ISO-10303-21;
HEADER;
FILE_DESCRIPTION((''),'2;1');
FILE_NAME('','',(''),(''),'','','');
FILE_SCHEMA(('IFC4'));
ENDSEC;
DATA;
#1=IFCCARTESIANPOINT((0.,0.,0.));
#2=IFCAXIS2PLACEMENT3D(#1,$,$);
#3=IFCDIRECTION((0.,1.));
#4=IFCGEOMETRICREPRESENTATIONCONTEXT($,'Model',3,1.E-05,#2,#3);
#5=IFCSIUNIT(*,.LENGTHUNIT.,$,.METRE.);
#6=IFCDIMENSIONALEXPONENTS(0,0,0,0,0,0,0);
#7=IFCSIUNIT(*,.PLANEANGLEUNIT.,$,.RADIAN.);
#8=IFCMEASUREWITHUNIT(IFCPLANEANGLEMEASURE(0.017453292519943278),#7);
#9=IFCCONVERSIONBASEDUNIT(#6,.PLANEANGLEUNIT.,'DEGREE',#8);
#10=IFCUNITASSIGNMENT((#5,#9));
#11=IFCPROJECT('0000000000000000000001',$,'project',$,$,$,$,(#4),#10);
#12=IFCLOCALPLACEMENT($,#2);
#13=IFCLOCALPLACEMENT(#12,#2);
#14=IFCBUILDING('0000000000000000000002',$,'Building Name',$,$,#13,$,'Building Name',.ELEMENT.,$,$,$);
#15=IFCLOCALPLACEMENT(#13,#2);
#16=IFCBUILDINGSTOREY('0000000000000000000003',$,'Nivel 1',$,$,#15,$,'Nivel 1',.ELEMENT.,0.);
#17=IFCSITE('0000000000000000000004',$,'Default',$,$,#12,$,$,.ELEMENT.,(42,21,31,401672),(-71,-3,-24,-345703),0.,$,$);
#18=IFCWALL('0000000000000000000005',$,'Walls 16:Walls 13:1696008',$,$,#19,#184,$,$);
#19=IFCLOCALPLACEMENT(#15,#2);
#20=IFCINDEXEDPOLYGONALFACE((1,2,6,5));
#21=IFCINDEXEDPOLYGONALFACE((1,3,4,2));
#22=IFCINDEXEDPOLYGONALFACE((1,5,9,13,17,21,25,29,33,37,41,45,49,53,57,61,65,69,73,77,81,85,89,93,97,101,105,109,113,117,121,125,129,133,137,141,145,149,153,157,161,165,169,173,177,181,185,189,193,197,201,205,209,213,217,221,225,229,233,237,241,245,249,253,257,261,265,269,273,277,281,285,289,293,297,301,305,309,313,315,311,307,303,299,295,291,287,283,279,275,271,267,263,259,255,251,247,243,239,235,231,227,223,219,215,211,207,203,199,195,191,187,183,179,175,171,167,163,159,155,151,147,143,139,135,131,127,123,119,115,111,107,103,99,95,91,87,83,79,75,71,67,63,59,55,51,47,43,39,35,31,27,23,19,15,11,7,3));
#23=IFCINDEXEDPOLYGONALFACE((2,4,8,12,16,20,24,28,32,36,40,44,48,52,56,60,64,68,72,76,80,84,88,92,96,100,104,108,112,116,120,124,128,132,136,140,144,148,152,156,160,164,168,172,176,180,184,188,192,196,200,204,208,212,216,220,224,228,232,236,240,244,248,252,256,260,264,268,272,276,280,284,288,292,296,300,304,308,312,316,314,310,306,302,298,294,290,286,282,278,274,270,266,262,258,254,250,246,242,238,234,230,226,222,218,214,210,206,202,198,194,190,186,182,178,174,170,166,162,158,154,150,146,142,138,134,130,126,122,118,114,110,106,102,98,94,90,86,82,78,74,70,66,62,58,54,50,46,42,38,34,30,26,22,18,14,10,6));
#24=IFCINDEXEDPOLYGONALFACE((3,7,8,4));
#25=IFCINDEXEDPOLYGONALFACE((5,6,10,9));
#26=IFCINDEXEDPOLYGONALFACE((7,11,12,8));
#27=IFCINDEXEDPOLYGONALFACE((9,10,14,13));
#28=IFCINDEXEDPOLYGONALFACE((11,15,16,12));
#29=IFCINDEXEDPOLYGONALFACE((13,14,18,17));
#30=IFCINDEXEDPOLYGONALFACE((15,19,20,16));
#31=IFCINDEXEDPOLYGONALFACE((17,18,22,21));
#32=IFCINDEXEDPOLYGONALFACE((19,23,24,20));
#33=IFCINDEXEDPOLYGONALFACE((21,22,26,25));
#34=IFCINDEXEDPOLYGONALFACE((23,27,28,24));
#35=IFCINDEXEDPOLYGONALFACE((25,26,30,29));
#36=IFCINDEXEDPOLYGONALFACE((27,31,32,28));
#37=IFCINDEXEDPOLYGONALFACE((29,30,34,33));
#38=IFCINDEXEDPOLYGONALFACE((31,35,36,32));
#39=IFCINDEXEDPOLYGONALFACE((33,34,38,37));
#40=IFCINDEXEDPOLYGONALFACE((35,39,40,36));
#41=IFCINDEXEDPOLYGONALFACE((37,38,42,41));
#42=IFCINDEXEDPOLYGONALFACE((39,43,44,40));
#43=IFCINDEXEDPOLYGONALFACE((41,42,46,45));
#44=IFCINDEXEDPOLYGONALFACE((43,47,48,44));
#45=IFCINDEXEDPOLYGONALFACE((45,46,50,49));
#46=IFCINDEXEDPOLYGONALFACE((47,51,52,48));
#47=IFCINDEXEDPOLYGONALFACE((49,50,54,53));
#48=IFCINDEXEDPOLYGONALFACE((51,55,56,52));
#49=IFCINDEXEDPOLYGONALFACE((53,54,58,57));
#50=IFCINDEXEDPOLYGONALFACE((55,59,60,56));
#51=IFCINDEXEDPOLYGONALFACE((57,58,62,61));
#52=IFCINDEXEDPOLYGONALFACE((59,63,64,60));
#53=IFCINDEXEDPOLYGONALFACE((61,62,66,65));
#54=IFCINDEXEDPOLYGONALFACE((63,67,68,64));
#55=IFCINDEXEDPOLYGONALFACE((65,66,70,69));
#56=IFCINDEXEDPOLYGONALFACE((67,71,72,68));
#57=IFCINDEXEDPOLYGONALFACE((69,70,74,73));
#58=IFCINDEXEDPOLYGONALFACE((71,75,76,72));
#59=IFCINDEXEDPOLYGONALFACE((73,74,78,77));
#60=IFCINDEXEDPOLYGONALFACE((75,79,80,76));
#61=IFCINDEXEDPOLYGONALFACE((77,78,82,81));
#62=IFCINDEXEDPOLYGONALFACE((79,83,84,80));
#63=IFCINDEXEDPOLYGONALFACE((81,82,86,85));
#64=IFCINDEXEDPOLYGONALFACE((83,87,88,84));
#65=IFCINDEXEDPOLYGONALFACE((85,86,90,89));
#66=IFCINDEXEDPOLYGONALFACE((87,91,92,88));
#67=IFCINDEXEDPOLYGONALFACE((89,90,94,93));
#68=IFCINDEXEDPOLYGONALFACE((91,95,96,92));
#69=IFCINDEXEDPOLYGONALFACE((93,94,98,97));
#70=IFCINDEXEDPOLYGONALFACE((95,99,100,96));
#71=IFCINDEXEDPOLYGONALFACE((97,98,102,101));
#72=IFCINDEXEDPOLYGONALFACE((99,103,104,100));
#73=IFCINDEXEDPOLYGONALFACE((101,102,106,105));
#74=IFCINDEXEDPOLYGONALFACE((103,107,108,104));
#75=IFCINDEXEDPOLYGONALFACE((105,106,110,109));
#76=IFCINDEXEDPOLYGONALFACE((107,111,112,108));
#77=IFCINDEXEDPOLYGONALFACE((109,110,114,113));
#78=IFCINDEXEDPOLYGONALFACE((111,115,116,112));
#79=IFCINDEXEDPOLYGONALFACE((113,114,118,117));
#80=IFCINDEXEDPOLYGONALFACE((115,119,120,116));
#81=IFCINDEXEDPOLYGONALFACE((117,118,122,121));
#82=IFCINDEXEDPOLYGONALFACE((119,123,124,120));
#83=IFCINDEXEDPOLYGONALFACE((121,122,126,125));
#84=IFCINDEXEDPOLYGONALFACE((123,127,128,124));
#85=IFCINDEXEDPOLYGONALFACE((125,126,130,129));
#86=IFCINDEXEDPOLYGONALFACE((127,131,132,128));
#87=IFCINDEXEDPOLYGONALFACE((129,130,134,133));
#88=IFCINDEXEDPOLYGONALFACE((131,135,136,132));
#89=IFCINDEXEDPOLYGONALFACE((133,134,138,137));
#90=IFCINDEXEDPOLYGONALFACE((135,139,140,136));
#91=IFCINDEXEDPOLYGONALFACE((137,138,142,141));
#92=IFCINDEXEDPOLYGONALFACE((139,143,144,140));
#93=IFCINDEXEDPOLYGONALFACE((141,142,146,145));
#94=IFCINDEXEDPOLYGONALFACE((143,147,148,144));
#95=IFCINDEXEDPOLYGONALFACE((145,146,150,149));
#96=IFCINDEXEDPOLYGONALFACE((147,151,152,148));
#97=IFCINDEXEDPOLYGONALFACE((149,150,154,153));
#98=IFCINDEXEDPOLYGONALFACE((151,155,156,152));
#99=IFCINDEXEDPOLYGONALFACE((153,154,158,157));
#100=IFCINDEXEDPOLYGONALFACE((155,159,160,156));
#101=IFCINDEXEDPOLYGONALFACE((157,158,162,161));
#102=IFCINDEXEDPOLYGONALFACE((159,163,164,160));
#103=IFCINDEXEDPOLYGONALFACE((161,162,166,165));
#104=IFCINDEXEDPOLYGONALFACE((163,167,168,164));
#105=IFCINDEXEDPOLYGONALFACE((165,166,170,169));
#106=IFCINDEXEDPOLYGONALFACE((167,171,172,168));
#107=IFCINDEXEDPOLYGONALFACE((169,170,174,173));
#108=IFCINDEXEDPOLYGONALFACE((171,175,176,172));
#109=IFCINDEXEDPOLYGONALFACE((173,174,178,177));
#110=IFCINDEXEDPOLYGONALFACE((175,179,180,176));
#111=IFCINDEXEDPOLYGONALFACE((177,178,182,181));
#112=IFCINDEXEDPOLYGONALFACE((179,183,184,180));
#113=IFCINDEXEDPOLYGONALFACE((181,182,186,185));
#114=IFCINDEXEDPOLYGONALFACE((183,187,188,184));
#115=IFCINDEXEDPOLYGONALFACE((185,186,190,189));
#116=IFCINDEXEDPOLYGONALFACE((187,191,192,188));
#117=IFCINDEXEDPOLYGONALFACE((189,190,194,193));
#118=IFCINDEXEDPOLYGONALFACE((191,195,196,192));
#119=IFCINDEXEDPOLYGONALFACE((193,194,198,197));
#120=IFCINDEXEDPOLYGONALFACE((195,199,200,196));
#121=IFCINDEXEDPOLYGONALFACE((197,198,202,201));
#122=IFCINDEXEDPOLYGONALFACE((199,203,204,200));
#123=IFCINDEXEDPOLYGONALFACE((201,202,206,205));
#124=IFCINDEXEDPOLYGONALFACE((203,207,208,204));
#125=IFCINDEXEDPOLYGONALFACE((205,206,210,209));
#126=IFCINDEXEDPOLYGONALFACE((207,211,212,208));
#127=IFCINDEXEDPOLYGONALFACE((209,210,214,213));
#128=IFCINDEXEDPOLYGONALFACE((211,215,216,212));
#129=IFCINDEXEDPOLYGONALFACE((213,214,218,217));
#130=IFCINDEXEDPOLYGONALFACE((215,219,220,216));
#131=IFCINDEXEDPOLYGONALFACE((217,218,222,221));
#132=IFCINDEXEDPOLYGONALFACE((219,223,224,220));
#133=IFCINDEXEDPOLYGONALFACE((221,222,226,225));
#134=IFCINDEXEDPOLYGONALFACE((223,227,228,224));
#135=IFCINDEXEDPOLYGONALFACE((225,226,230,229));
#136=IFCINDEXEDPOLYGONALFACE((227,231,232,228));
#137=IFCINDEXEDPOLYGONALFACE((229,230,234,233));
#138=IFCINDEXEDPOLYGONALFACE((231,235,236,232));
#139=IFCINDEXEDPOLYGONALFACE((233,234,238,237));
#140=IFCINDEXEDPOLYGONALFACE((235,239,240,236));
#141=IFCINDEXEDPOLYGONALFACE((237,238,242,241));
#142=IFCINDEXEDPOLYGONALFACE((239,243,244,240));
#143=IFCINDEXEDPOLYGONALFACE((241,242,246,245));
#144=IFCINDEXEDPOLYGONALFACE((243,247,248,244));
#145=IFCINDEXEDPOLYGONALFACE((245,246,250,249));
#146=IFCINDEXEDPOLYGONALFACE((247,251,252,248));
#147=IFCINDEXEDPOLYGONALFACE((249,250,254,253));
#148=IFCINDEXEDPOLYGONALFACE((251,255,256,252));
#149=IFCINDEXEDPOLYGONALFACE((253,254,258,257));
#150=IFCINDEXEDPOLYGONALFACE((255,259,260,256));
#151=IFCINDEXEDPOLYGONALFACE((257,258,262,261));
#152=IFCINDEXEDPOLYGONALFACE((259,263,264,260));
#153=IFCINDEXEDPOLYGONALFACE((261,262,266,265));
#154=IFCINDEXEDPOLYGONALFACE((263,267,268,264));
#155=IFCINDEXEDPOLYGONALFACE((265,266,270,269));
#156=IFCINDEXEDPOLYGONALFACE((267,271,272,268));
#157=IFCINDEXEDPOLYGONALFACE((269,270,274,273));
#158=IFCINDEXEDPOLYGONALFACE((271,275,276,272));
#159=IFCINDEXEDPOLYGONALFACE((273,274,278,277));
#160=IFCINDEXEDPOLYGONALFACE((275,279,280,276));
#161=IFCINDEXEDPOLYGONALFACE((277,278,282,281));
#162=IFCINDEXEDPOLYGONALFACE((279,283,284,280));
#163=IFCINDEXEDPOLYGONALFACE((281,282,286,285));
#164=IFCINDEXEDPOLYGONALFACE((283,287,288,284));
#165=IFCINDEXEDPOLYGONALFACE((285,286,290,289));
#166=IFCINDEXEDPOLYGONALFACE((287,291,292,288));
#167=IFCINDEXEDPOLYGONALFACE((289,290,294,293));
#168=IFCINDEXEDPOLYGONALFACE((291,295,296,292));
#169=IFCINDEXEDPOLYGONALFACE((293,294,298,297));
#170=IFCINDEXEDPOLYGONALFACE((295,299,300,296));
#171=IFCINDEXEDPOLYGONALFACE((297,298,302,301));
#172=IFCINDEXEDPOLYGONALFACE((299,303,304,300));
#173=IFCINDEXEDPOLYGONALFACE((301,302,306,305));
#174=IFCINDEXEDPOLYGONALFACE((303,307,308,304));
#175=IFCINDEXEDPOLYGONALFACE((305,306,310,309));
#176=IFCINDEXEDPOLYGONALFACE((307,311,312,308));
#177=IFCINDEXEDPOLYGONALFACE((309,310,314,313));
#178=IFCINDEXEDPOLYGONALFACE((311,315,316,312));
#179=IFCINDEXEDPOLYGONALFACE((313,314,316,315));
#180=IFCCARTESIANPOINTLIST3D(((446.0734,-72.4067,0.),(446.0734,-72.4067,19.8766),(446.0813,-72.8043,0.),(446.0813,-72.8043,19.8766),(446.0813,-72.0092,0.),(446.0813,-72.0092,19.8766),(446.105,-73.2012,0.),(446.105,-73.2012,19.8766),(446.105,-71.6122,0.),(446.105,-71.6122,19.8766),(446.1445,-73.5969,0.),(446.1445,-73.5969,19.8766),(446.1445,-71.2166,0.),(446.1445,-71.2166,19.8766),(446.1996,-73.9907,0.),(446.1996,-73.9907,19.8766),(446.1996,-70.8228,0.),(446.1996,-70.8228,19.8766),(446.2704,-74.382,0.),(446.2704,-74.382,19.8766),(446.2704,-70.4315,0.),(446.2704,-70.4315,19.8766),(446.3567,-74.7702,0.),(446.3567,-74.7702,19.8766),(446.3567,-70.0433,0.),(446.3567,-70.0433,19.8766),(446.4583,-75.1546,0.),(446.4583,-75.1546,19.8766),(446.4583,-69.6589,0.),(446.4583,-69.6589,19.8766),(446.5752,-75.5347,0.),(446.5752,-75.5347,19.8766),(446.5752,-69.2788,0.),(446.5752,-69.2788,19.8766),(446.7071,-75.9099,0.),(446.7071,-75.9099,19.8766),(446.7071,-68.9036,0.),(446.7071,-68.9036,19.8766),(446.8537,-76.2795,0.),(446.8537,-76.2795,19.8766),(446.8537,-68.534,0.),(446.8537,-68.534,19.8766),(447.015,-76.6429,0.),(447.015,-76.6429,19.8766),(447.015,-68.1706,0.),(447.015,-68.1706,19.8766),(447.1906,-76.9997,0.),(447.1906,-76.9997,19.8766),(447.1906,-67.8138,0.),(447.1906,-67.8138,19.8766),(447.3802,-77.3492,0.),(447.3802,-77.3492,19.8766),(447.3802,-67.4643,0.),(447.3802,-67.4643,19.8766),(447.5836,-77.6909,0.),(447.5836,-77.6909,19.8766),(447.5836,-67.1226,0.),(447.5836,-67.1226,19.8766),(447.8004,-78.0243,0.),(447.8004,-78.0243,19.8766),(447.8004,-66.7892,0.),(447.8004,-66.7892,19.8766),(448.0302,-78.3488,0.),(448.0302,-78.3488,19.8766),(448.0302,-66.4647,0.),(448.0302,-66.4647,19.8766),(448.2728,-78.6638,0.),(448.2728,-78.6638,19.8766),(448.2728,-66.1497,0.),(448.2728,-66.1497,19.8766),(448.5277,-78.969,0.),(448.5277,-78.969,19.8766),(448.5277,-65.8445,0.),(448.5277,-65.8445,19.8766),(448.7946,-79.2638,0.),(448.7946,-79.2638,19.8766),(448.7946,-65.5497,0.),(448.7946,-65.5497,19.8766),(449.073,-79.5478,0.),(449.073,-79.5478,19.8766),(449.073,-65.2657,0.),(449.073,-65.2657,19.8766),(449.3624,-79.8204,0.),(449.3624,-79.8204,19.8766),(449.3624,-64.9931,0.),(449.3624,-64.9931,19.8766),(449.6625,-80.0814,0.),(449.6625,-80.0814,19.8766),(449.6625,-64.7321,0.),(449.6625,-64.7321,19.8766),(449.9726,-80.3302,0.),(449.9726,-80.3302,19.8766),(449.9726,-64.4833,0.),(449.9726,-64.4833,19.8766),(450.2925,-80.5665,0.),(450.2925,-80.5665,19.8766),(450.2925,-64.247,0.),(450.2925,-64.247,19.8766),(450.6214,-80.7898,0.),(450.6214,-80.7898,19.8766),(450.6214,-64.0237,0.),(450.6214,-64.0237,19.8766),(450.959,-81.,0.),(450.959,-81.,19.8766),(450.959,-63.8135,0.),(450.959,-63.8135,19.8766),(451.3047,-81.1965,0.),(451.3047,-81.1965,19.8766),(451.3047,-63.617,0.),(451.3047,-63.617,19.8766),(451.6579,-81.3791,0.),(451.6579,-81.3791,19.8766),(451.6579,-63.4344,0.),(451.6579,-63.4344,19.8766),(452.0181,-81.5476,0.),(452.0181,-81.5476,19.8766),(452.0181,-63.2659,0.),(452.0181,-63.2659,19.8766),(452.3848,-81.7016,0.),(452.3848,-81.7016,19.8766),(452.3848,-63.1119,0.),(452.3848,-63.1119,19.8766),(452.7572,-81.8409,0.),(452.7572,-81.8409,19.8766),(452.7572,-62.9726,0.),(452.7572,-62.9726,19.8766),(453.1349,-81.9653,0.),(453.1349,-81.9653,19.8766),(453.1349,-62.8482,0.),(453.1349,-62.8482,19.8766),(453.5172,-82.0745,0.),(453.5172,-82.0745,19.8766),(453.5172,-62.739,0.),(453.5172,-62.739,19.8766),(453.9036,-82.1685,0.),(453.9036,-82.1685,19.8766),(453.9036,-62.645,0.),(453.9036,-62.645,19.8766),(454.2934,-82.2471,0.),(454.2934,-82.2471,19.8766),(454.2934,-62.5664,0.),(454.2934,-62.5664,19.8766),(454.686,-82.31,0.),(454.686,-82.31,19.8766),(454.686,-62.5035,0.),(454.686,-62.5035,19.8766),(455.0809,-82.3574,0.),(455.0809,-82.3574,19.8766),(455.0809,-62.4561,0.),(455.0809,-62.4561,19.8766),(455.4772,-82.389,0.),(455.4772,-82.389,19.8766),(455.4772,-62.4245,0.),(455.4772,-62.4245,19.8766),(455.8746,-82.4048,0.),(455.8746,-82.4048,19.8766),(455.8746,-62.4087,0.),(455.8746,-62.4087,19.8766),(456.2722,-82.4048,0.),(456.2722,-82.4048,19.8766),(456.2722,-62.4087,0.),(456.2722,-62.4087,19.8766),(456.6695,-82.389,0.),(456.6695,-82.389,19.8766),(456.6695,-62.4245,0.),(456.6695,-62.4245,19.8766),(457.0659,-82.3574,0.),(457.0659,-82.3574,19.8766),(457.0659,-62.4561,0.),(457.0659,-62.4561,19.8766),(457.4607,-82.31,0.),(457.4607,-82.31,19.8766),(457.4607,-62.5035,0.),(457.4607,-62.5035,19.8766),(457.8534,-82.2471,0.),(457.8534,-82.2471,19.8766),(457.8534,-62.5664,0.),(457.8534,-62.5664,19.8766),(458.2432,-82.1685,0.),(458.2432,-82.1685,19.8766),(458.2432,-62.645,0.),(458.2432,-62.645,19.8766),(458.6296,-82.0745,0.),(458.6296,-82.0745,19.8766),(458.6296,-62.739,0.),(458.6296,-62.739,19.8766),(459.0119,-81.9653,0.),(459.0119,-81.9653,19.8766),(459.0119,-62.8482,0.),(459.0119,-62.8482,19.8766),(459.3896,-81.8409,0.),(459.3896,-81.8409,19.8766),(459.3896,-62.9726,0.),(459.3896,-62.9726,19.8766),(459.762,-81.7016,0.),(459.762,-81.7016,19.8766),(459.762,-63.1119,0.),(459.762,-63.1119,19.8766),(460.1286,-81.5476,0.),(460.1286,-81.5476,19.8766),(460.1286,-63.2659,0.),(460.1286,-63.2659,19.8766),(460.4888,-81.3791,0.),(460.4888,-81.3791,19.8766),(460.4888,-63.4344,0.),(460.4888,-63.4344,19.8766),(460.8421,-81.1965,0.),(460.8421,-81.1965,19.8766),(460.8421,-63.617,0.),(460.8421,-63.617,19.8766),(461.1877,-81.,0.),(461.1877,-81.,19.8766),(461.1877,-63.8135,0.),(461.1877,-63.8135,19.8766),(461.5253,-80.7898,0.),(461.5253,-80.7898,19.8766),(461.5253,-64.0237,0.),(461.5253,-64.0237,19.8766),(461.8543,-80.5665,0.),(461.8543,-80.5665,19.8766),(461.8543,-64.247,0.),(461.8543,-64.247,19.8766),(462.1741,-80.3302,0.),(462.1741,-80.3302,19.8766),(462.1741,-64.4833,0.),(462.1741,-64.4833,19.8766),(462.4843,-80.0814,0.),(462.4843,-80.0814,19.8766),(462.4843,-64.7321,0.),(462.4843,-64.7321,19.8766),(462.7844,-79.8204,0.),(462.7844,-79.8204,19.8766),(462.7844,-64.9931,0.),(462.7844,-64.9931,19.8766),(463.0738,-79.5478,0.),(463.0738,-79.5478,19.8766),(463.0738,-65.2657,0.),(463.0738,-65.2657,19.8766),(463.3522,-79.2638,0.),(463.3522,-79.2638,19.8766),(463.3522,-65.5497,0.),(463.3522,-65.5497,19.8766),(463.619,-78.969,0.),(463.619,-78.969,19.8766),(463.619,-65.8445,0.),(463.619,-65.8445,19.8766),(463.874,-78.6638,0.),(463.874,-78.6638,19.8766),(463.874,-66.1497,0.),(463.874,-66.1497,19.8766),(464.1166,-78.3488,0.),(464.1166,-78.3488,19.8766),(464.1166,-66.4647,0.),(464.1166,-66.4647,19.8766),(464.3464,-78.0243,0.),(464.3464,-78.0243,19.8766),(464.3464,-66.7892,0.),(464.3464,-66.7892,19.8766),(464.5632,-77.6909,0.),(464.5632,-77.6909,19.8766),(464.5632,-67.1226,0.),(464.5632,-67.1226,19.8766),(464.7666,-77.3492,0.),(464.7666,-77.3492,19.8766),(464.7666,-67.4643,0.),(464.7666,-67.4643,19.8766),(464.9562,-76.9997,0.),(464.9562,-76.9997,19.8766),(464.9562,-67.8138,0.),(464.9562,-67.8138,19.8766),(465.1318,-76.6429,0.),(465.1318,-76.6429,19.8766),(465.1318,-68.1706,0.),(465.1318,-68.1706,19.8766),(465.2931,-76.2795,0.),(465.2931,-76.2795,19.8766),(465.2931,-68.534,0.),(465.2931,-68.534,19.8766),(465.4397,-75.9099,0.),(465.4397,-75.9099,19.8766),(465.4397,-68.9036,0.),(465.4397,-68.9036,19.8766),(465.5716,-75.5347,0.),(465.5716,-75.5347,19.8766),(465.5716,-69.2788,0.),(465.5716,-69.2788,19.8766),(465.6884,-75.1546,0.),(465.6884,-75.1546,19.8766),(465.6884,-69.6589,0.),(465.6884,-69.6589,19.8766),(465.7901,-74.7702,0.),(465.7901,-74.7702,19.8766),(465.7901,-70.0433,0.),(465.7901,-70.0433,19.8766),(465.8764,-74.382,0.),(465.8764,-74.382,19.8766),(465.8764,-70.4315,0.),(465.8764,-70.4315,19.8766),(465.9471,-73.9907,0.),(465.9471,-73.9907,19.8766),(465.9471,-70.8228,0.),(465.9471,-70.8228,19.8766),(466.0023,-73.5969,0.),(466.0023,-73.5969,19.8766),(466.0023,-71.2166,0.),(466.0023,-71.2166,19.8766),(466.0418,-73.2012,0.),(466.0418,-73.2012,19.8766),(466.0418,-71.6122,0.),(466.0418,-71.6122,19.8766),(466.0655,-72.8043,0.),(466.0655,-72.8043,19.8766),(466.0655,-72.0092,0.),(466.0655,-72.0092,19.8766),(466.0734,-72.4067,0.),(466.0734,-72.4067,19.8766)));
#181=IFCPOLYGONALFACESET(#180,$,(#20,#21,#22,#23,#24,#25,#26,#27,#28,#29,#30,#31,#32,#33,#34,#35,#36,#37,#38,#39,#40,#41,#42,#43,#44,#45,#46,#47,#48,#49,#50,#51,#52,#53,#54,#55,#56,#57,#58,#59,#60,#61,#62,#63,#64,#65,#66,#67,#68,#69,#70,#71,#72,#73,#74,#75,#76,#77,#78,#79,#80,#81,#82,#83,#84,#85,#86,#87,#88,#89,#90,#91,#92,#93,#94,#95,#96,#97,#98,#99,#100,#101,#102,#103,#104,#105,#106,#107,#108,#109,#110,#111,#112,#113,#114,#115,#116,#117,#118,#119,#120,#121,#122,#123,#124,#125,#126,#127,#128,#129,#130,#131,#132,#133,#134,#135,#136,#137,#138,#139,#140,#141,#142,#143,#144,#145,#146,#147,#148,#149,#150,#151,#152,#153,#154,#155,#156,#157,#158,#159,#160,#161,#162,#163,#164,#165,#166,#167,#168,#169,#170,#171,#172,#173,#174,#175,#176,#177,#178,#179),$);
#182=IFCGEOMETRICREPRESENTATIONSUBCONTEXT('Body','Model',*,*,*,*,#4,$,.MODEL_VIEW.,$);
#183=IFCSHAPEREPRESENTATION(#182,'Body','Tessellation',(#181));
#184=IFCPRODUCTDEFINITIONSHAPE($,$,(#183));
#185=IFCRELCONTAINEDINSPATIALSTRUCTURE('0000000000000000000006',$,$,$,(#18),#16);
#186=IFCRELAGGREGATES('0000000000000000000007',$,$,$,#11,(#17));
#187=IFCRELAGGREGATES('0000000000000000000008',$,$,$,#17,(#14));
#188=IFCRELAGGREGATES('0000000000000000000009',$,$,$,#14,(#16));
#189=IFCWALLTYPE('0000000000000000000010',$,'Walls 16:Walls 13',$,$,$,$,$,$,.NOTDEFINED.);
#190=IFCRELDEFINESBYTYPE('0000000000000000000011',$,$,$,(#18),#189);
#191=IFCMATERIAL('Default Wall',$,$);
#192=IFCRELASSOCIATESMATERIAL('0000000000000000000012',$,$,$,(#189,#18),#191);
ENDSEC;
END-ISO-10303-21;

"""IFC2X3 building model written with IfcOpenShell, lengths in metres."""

from ifc_helpers import new_model, entity, si_unit, converted_unit, direction, frame, frame_2d, origin, place, context, subcontext, project, spatial, circle, extrude, material, type_object, element, save


model = new_model("IFC2X3")

# Units and contexts
model_context = context("Model", 3, precision=1e-05, world=origin(), true_north=direction((0.0, 1.0)))
body_context = subcontext(model_context, "Body", "Model", "MODEL_VIEW")
ifc_project = project(units=[si_unit("LENGTHUNIT", "METRE"), converted_unit("PLANEANGLEUNIT", "DEGREE", entity("IfcPlaneAngleMeasure", 0.017453292519943278), si_unit("PLANEANGLEUNIT", "RADIAN"), dimensions=[0, 0, 0, 0, 0, 0, 0])], contexts=[model_context])

# Site, building, storey
site_placement = place(None, origin())
site = spatial("IfcSite", under=ifc_project, at=site_placement, Name="Default", CompositionType="ELEMENT", RefLatitude=(42, 21, 31, 401672), RefLongitude=(-71, -3, -24, -345703), RefElevation=0.0)
building_placement = place(site_placement, origin())
building = spatial("IfcBuilding", under=site, at=building_placement, Name="Building Name", LongName="Building Name", CompositionType="ELEMENT")
storey_placement = place(building_placement, origin())
storey = spatial("IfcBuildingStorey", under=building, at=storey_placement, Name="Nivel 1", LongName="Nivel 1", CompositionType="ELEMENT", Elevation=0.0)

# Wall
ifc_material_1 = material(Name="Default Wall")
wall_type_1 = type_object("IfcWallType", Name="Walls 16:Walls 13", PredefinedType="NOTDEFINED", material=ifc_material_1)
wall_1_placement = place(storey_placement, frame((446.0734, -82.4067, 0.0)))
element("IfcWall", 1, at=wall_1_placement, inside=storey, type_object=wall_type_1, material=ifc_material_1, Name="Walls 16:Walls 13:1696008", context=body_context, shape_type="SweptSolid", body=[
    extrude(circle(Radius=10.0, at=frame_2d((0.0, 0.0), x_axis=(1.0, 0.0))), frame((10.0, 10.0, 0.0)), (0.0, 0.0, 1.0), 19.8766),
])

save(model, "model.ifc")
